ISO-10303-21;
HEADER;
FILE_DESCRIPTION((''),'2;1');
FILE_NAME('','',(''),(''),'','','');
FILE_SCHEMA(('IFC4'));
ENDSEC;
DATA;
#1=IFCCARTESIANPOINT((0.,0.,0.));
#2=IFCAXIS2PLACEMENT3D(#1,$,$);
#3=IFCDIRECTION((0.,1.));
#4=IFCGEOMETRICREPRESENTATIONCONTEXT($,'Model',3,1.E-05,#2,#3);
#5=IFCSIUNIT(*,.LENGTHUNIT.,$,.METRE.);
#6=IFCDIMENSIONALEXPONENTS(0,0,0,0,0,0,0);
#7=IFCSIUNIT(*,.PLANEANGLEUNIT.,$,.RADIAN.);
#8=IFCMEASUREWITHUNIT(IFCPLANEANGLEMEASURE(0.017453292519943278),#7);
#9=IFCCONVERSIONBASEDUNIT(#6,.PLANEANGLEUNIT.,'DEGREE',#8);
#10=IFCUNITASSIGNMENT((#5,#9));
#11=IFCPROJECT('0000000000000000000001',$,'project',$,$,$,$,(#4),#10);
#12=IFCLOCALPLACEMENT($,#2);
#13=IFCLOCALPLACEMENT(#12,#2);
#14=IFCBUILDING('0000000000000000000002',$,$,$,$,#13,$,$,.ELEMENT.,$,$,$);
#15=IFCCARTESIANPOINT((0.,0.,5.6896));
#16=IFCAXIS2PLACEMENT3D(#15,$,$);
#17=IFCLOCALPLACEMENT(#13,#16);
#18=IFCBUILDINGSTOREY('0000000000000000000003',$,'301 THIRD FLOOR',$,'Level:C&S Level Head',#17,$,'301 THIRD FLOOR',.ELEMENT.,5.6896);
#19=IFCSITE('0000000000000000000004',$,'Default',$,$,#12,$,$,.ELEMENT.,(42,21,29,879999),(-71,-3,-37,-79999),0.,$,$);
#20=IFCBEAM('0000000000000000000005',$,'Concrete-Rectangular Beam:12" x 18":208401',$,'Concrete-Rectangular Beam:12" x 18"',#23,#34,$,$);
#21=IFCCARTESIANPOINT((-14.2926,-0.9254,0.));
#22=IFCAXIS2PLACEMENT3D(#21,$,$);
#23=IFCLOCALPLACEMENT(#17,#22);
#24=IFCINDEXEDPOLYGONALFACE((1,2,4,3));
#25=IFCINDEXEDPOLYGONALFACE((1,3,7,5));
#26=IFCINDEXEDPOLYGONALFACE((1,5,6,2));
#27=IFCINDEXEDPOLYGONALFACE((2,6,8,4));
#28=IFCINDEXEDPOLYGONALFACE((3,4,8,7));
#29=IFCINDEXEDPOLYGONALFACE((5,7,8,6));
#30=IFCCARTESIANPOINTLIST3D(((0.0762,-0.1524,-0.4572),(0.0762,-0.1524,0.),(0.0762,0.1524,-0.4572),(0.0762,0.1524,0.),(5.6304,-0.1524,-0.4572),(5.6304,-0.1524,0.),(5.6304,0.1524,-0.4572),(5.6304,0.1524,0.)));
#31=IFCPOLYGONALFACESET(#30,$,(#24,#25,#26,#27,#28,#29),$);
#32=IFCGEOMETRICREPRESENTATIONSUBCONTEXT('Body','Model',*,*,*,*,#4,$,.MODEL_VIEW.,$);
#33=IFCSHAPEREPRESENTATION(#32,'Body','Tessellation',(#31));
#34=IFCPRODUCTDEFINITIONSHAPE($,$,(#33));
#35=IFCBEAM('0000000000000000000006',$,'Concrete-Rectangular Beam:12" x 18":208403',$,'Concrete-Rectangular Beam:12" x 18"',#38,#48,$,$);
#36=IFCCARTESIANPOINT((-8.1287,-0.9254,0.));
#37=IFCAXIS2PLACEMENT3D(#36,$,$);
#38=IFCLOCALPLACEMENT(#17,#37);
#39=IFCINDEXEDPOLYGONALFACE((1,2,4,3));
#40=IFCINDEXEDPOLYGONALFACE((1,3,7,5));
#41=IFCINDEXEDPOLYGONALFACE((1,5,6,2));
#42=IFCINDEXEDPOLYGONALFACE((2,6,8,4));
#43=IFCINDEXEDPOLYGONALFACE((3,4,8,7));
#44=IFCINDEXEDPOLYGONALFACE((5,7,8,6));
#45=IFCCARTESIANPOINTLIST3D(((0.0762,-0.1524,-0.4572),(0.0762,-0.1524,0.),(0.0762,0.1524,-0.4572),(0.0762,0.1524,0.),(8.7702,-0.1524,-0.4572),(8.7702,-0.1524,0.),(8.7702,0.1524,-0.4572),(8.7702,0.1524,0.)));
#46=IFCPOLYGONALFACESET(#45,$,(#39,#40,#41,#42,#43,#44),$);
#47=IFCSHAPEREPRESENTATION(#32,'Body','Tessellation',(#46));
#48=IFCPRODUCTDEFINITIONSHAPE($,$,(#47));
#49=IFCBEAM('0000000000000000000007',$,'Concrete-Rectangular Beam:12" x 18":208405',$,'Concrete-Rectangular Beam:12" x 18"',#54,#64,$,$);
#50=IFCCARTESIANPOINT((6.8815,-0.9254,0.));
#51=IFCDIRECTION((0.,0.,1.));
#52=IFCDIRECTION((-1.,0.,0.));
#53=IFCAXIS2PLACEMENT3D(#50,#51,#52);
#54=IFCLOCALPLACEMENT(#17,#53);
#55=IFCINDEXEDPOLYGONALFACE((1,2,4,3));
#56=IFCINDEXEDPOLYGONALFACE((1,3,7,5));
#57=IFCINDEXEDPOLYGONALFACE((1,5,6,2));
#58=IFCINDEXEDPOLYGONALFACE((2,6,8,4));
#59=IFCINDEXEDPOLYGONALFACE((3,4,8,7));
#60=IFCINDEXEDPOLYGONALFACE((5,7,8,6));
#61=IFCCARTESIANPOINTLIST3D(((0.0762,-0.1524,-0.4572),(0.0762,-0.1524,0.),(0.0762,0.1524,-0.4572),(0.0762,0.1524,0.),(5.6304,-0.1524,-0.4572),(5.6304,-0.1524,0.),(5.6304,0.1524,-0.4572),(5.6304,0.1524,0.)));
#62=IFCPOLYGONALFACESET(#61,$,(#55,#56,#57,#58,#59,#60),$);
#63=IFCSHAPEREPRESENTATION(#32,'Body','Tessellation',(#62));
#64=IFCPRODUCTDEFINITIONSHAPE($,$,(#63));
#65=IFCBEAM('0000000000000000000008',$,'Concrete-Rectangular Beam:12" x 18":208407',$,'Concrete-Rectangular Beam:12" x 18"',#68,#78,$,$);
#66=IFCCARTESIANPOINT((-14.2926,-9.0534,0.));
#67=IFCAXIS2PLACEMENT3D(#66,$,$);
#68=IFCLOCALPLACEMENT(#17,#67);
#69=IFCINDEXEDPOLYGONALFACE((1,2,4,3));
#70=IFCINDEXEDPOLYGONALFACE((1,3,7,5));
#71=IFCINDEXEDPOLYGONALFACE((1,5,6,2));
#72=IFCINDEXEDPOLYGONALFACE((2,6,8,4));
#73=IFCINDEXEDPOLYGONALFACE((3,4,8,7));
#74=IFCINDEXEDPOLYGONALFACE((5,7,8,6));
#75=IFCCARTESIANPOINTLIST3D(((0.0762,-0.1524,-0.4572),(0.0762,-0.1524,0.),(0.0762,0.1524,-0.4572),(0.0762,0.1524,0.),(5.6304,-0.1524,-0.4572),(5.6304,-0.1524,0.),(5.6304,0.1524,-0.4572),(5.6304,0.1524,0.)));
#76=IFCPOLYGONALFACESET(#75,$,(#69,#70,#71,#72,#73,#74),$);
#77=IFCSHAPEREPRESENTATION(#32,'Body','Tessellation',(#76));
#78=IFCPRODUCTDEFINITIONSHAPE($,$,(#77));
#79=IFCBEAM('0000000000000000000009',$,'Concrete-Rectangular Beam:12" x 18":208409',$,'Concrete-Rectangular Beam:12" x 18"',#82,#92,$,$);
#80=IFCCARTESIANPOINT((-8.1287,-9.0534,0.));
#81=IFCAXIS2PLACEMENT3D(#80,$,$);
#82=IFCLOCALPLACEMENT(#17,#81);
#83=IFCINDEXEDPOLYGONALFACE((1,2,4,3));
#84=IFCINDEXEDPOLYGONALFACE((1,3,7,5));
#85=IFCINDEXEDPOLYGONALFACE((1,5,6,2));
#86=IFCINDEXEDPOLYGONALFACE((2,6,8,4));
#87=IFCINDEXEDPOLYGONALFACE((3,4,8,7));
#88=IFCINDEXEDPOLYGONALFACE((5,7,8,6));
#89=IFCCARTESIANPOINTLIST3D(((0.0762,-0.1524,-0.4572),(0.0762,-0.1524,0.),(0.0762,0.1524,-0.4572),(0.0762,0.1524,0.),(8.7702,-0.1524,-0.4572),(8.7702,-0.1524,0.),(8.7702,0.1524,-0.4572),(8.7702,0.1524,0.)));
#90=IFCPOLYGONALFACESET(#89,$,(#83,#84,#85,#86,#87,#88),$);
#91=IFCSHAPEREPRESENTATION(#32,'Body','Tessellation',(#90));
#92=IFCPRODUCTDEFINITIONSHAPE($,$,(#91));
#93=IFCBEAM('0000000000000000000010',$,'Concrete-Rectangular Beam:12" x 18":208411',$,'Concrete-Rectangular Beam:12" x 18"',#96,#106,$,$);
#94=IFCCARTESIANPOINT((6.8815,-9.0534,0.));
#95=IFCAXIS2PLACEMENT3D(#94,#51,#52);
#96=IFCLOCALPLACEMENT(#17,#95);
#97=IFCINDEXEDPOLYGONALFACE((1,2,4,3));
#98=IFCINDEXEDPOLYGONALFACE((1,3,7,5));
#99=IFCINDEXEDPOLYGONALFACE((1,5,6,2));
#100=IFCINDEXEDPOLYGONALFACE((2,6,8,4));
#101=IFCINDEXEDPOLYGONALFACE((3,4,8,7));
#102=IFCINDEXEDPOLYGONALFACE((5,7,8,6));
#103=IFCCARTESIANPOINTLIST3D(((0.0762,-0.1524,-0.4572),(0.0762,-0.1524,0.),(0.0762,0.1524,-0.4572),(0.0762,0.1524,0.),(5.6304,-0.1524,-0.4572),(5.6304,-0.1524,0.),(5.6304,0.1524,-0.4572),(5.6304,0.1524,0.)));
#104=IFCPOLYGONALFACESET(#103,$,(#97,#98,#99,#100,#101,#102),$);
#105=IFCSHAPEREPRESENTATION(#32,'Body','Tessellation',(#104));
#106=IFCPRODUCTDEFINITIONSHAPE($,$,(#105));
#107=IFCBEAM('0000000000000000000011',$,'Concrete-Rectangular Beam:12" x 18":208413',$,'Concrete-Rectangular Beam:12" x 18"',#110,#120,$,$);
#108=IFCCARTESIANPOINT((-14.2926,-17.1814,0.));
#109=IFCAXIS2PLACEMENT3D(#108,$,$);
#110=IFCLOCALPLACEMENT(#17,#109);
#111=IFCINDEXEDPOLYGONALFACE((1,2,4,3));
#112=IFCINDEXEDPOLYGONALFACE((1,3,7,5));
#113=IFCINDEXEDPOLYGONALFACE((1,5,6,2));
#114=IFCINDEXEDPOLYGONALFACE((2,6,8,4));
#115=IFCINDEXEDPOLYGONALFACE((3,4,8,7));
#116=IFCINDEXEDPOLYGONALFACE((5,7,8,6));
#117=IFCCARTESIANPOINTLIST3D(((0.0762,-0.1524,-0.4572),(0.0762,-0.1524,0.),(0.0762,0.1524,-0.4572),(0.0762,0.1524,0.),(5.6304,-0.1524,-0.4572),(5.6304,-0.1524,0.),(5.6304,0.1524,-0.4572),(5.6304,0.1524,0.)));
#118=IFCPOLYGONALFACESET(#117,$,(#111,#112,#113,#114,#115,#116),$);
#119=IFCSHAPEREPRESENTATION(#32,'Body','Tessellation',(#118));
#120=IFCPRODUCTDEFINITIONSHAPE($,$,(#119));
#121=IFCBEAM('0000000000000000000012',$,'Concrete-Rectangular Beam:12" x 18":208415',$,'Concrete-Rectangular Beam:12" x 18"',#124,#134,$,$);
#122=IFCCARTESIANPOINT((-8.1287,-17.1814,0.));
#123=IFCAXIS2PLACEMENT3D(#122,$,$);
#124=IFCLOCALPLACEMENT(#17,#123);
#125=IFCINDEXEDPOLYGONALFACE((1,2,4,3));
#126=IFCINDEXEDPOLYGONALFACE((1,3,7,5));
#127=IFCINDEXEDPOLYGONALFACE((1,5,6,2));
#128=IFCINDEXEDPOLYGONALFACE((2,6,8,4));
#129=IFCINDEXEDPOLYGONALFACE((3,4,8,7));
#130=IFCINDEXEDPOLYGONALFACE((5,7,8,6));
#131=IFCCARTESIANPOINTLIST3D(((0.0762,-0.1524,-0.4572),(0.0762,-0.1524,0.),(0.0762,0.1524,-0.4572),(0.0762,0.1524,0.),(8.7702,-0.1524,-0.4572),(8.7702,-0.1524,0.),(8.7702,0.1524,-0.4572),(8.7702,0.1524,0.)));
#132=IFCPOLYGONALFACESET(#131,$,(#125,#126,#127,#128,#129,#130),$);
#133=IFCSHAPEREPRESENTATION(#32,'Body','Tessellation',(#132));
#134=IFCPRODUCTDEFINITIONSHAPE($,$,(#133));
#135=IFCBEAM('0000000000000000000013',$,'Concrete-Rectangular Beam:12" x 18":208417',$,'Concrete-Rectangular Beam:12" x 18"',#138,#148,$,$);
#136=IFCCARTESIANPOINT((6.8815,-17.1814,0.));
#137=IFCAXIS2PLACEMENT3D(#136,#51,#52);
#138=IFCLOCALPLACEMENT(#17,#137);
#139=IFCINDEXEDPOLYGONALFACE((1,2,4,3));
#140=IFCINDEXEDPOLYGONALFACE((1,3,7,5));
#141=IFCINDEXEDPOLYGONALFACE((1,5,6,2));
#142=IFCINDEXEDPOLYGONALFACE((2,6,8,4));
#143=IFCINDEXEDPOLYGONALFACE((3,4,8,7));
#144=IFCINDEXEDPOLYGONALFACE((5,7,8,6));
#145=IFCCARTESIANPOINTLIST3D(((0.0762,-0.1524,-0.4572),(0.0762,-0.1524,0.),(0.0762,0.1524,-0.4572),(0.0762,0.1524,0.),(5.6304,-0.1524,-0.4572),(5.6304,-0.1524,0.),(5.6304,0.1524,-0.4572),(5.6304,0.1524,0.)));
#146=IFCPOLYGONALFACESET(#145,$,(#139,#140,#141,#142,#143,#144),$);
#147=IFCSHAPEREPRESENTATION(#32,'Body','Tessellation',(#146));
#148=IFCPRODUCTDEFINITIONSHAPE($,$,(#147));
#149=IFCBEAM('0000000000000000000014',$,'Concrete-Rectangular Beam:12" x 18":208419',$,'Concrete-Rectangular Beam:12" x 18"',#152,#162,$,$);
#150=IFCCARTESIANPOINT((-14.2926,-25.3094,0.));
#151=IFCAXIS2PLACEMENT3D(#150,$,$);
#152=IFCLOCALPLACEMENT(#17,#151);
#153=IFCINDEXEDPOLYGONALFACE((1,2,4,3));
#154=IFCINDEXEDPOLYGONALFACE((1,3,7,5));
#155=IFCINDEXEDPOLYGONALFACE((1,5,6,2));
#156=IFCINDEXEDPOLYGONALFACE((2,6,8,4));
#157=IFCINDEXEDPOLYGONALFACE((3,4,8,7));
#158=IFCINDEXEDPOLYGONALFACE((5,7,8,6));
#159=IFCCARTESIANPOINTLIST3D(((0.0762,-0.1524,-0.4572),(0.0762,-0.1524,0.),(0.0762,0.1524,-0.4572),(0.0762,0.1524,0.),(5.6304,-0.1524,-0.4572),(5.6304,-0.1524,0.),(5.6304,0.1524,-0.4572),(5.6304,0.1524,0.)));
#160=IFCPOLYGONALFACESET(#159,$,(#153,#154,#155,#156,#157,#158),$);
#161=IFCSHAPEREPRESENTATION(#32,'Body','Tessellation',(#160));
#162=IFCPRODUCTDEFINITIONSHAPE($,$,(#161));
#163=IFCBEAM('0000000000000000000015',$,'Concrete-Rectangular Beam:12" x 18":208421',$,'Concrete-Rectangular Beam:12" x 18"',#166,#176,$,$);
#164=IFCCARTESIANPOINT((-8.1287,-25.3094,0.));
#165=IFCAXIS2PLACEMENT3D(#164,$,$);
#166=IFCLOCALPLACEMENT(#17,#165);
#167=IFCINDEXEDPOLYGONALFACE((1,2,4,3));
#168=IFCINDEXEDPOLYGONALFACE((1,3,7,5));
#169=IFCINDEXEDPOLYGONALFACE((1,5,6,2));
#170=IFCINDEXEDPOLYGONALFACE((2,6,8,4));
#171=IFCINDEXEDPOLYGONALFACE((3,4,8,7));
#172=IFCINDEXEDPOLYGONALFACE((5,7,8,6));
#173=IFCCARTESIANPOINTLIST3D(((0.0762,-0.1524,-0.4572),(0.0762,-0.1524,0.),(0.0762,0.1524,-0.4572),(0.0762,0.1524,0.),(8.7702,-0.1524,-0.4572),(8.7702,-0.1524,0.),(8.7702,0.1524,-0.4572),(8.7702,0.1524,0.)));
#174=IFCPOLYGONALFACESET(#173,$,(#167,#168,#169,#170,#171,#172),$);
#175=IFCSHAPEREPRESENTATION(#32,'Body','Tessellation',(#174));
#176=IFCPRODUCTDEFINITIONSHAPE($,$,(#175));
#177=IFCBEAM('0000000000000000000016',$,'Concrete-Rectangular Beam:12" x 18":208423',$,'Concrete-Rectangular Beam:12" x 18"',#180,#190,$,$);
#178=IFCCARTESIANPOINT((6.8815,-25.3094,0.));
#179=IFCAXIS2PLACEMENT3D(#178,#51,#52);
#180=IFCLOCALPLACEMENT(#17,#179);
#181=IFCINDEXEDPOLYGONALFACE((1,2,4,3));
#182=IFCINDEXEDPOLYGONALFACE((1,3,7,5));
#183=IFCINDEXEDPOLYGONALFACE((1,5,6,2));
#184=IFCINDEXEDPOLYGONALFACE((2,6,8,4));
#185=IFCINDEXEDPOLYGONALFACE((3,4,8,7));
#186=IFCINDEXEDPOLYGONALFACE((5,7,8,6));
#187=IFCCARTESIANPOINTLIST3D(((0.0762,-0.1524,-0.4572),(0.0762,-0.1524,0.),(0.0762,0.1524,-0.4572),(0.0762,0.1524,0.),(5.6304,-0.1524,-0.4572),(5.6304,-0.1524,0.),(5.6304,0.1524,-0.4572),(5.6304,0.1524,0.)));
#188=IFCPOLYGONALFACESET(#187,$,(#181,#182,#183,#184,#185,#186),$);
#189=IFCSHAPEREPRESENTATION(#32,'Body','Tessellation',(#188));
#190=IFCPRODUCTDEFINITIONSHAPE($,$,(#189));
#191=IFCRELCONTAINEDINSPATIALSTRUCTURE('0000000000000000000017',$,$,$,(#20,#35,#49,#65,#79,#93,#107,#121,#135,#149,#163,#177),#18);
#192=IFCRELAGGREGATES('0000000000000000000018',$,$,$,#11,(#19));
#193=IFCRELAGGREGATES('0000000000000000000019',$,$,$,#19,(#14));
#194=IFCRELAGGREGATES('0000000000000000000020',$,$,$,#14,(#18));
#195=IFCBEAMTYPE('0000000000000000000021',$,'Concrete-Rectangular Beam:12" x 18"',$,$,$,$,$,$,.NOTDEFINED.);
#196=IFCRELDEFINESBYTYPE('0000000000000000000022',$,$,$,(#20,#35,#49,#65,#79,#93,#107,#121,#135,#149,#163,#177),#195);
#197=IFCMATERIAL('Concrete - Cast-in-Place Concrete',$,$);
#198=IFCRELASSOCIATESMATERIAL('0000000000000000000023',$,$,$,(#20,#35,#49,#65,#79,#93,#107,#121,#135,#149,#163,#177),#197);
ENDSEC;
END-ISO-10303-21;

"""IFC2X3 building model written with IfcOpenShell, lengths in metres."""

from ifc_helpers import new_model, entity, si_unit, converted_unit, direction, frame, frame_2d, origin, origin_2d_with_axis, place, context, subcontext, project, spatial, rectangle, extrude, material, type_object, element, save


model = new_model("IFC2X3")

# Units and contexts
model_context = context("Model", 3, precision=1e-05, world=origin(), true_north=direction((0.0, 1.0)))
body_context = subcontext(model_context, "Body", "Model", "MODEL_VIEW")
ifc_project = project(units=[si_unit("LENGTHUNIT", "METRE"), converted_unit("PLANEANGLEUNIT", "DEGREE", entity("IfcPlaneAngleMeasure", 0.017453292519943278), si_unit("PLANEANGLEUNIT", "RADIAN"), dimensions=[0, 0, 0, 0, 0, 0, 0])], contexts=[model_context])

# Site, building, storey
site_placement = place(None, origin())
site = spatial("IfcSite", under=ifc_project, at=site_placement, Name="Default", CompositionType="ELEMENT", RefLatitude=(42, 21, 29, 879999), RefLongitude=(-71, -3, -37, -79999), RefElevation=0.0)
building_placement = place(site_placement, origin())
building = spatial("IfcBuilding", under=site, at=building_placement, CompositionType="ELEMENT")
storey_placement = place(building_placement, frame((0.0, 0.0, 5.6896)))
storey = spatial("IfcBuildingStorey", under=building, at=storey_placement, Name="301 THIRD FLOOR", ObjectType="Level:C&S Level Head", LongName="301 THIRD FLOOR", CompositionType="ELEMENT", Elevation=5.6896)

# Beams
ifc_material_1 = material(Name="Concrete - Cast-in-Place Concrete")
beam_type = type_object("IfcBeamType", Name="Concrete-Rectangular Beam:12\" x 18\"", PredefinedType="NOTDEFINED")
beam_1_placement = place(storey_placement, frame((-14.2926, -0.9254, 0.0)))
element("IfcBeam", 1, at=beam_1_placement, inside=storey, type_object=beam_type, material=ifc_material_1, Name="Concrete-Rectangular Beam:12\" x 18\":208401", ObjectType="Concrete-Rectangular Beam:12\" x 18\"", context=body_context, shape_type="SweptSolid", body=[
    extrude(rectangle(XDim=0.4572, YDim=0.3048, at=frame_2d((0.0, 0.0), x_axis=(1.0, 0.0))), frame((0.0762, 0.0, -0.2286), z_axis=(1.0, 0.0, 0.0), x_axis=(0.0, 0.0, -1.0)), (0.0, 0.0, 1.0), 5.5542),
])
beam_2_placement = place(storey_placement, frame((-8.1287, -0.9254, 0.0)))
element("IfcBeam", 2, at=beam_2_placement, inside=storey, type_object=beam_type, material=ifc_material_1, Name="Concrete-Rectangular Beam:12\" x 18\":208403", ObjectType="Concrete-Rectangular Beam:12\" x 18\"", context=body_context, shape_type="SweptSolid", body=[
    extrude(rectangle(XDim=0.4572, YDim=0.3048, at=frame_2d((0.0, 0.0), x_axis=(1.0, 0.0))), frame((0.0762, 0.0, -0.2286), z_axis=(1.0, 0.0, 0.0), x_axis=(0.0, 0.0, -1.0)), (0.0, 0.0, 1.0), 8.694),
])
beam_3_placement = place(storey_placement, frame((6.8815, -0.9254, 0.0), z_axis=(0.0, 0.0, 1.0), x_axis=(-1.0, 0.0, 0.0)))
element("IfcBeam", 3, at=beam_3_placement, inside=storey, type_object=beam_type, material=ifc_material_1, Name="Concrete-Rectangular Beam:12\" x 18\":208405", ObjectType="Concrete-Rectangular Beam:12\" x 18\"", context=body_context, shape_type="SweptSolid", body=[
    extrude(rectangle(XDim=0.4572, YDim=0.3048, at=frame_2d((0.0, 0.0), x_axis=(1.0, 0.0))), frame((0.0762, 0.0, -0.2286), z_axis=(1.0, 0.0, 0.0), x_axis=(0.0, 0.0, -1.0)), (0.0, 0.0, 1.0), 5.5542),
])
beam_4_placement = place(storey_placement, frame((-14.2926, -9.0534, 0.0)))
element("IfcBeam", 4, at=beam_4_placement, inside=storey, type_object=beam_type, material=ifc_material_1, Name="Concrete-Rectangular Beam:12\" x 18\":208407", ObjectType="Concrete-Rectangular Beam:12\" x 18\"", context=body_context, shape_type="SweptSolid", body=[
    extrude(rectangle(XDim=0.4572, YDim=0.3048, at=frame_2d((0.0, 0.0), x_axis=(1.0, 0.0))), frame((0.0762, 0.0, -0.2286), z_axis=(1.0, 0.0, 0.0), x_axis=(0.0, 0.0, -1.0)), (0.0, 0.0, 1.0), 5.5542),
])
beam_5_placement = place(storey_placement, frame((-8.1287, -9.0534, 0.0)))
element("IfcBeam", 5, at=beam_5_placement, inside=storey, type_object=beam_type, material=ifc_material_1, Name="Concrete-Rectangular Beam:12\" x 18\":208409", ObjectType="Concrete-Rectangular Beam:12\" x 18\"", context=body_context, shape_type="SweptSolid", body=[
    extrude(rectangle(XDim=0.4572, YDim=0.3048, at=frame_2d((0.0, 0.0), x_axis=(1.0, 0.0))), frame((0.0762, 0.0, -0.2286), z_axis=(1.0, 0.0, 0.0), x_axis=(0.0, 0.0, -1.0)), (0.0, 0.0, 1.0), 8.694),
])
beam_6_placement = place(storey_placement, frame((6.8815, -9.0534, 0.0), z_axis=(0.0, 0.0, 1.0), x_axis=(-1.0, 0.0, 0.0)))
element("IfcBeam", 6, at=beam_6_placement, inside=storey, type_object=beam_type, material=ifc_material_1, Name="Concrete-Rectangular Beam:12\" x 18\":208411", ObjectType="Concrete-Rectangular Beam:12\" x 18\"", context=body_context, shape_type="SweptSolid", body=[
    extrude(rectangle(XDim=0.4572, YDim=0.3048, at=frame_2d((0.0, 0.0), x_axis=(1.0, 0.0))), frame((0.0762, 0.0, -0.2286), z_axis=(1.0, 0.0, 0.0), x_axis=(0.0, 0.0, -1.0)), (0.0, 0.0, 1.0), 5.5542),
])
beam_7_placement = place(storey_placement, frame((-14.2926, -17.1814, 0.0)))
element("IfcBeam", 7, at=beam_7_placement, inside=storey, type_object=beam_type, material=ifc_material_1, Name="Concrete-Rectangular Beam:12\" x 18\":208413", ObjectType="Concrete-Rectangular Beam:12\" x 18\"", context=body_context, shape_type="SweptSolid", body=[
    extrude(rectangle(XDim=0.4572, YDim=0.3048, at=origin_2d_with_axis()), frame((0.0762, 0.0, -0.2286), z_axis=(1.0, 0.0, 0.0), x_axis=(0.0, 0.0, -1.0)), (0.0, 0.0, 1.0), 5.5542),
])
beam_8_placement = place(storey_placement, frame((-8.1287, -17.1814, 0.0)))
element("IfcBeam", 8, at=beam_8_placement, inside=storey, type_object=beam_type, material=ifc_material_1, Name="Concrete-Rectangular Beam:12\" x 18\":208415", ObjectType="Concrete-Rectangular Beam:12\" x 18\"", context=body_context, shape_type="SweptSolid", body=[
    extrude(rectangle(XDim=0.4572, YDim=0.3048, at=origin_2d_with_axis()), frame((0.0762, 0.0, -0.2286), z_axis=(1.0, 0.0, 0.0), x_axis=(0.0, 0.0, -1.0)), (0.0, 0.0, 1.0), 8.694),
])
beam_9_placement = place(storey_placement, frame((6.8815, -17.1814, 0.0), z_axis=(0.0, 0.0, 1.0), x_axis=(-1.0, 0.0, 0.0)))
element("IfcBeam", 9, at=beam_9_placement, inside=storey, type_object=beam_type, material=ifc_material_1, Name="Concrete-Rectangular Beam:12\" x 18\":208417", ObjectType="Concrete-Rectangular Beam:12\" x 18\"", context=body_context, shape_type="SweptSolid", body=[
    extrude(rectangle(XDim=0.4572, YDim=0.3048, at=origin_2d_with_axis()), frame((0.0762, 0.0, -0.2286), z_axis=(1.0, 0.0, 0.0), x_axis=(0.0, 0.0, -1.0)), (0.0, 0.0, 1.0), 5.5542),
])
beam_10_placement = place(storey_placement, frame((-14.2926, -25.3094, 0.0)))
element("IfcBeam", 10, at=beam_10_placement, inside=storey, type_object=beam_type, material=ifc_material_1, Name="Concrete-Rectangular Beam:12\" x 18\":208419", ObjectType="Concrete-Rectangular Beam:12\" x 18\"", context=body_context, shape_type="SweptSolid", body=[
    extrude(rectangle(XDim=0.4572, YDim=0.3048, at=frame_2d((0.0, 0.0), x_axis=(1.0, 0.0))), frame((0.0762, 0.0, -0.2286), z_axis=(1.0, 0.0, 0.0), x_axis=(0.0, 0.0, -1.0)), (0.0, 0.0, 1.0), 5.5542),
])
beam_11_placement = place(storey_placement, frame((-8.1287, -25.3094, 0.0)))
element("IfcBeam", 11, at=beam_11_placement, inside=storey, type_object=beam_type, material=ifc_material_1, Name="Concrete-Rectangular Beam:12\" x 18\":208421", ObjectType="Concrete-Rectangular Beam:12\" x 18\"", context=body_context, shape_type="SweptSolid", body=[
    extrude(rectangle(XDim=0.4572, YDim=0.3048, at=origin_2d_with_axis()), frame((0.0762, 0.0, -0.2286), z_axis=(1.0, 0.0, 0.0), x_axis=(0.0, 0.0, -1.0)), (0.0, 0.0, 1.0), 8.694),
])
beam_12_placement = place(storey_placement, frame((6.8815, -25.3094, 0.0), z_axis=(0.0, 0.0, 1.0), x_axis=(-1.0, 0.0, 0.0)))
element("IfcBeam", 12, at=beam_12_placement, inside=storey, type_object=beam_type, material=ifc_material_1, Name="Concrete-Rectangular Beam:12\" x 18\":208423", ObjectType="Concrete-Rectangular Beam:12\" x 18\"", context=body_context, shape_type="SweptSolid", body=[
    extrude(rectangle(XDim=0.4572, YDim=0.3048, at=frame_2d((0.0, 0.0), x_axis=(1.0, 0.0))), frame((0.0762, 0.0, -0.2286), z_axis=(1.0, 0.0, 0.0), x_axis=(0.0, 0.0, -1.0)), (0.0, 0.0, 1.0), 5.5542),
])

save(model, "model.ifc")
